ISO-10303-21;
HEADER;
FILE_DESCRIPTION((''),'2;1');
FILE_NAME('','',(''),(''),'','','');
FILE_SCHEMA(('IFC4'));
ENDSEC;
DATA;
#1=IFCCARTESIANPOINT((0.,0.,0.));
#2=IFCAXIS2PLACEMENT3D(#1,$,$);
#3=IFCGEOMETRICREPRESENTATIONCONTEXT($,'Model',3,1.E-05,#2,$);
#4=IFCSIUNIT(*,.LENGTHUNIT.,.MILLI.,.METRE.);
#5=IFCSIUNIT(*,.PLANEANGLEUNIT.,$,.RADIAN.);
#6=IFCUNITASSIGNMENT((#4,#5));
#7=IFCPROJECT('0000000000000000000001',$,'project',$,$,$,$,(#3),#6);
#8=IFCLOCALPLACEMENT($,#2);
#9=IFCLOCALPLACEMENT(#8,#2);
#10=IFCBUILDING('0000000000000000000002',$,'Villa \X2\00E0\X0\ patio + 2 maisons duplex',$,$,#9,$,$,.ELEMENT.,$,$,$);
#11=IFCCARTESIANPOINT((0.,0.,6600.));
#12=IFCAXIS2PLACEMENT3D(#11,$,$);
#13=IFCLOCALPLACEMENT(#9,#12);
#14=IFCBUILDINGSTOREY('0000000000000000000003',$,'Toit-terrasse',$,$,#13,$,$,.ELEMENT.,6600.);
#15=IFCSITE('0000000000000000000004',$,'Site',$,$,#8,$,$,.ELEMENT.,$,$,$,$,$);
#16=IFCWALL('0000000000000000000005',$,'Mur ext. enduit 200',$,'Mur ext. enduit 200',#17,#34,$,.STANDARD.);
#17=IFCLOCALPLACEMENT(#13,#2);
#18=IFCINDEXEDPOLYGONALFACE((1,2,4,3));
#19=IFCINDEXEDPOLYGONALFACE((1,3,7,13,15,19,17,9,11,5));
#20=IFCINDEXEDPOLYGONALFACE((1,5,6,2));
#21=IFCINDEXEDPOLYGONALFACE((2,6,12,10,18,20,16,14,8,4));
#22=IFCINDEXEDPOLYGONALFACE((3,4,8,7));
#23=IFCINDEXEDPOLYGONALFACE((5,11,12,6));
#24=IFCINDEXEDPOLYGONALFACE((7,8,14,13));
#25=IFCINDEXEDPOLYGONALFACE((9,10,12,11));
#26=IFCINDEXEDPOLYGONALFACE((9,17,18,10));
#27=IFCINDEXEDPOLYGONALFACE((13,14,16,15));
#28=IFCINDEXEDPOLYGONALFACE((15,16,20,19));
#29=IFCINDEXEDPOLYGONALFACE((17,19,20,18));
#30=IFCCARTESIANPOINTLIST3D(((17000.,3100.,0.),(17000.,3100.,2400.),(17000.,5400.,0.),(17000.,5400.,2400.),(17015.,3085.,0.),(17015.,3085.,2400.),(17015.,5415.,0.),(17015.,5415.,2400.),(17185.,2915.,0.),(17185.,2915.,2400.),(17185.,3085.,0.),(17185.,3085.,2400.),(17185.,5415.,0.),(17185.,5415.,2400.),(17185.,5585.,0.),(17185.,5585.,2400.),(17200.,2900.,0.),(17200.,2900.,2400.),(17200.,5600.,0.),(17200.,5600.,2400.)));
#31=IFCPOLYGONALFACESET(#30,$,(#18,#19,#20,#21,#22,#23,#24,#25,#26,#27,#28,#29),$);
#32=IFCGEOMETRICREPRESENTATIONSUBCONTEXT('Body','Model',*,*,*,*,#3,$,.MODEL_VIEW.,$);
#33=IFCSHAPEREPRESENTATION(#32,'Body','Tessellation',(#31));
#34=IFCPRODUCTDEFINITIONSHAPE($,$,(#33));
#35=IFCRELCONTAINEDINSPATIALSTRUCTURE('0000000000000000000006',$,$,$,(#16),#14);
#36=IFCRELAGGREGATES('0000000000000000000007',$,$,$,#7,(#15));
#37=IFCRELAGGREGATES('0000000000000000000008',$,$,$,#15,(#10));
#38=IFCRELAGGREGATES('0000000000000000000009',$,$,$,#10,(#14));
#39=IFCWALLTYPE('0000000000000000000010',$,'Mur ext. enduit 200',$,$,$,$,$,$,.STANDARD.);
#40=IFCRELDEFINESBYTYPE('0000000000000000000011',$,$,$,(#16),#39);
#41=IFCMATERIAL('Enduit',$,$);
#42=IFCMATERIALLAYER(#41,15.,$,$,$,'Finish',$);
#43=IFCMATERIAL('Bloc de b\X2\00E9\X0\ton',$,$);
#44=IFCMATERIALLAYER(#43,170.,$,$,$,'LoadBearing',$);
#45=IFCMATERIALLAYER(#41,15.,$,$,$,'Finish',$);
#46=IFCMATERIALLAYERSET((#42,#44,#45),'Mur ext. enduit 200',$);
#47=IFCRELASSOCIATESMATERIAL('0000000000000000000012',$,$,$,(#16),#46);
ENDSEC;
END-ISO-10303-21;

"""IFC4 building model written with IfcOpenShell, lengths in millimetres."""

from ifc_helpers import new_model, si_unit, frame, origin, place, context, subcontext, project, spatial, polyline, outline, extrude, material, layer, layer_set, layer_usage, type_object, element, save


model = new_model("IFC4")

# Units and contexts
model_context = context("Model", 3, precision=1e-05, world=origin())
body_context = subcontext(model_context, "Body", "Model", "MODEL_VIEW")
ifc_project = project(units=[si_unit("LENGTHUNIT", "METRE", prefix="MILLI"), si_unit("PLANEANGLEUNIT", "RADIAN")], contexts=[model_context])

# Site, building, storey
site_placement = place(None, origin())
site = spatial("IfcSite", under=ifc_project, at=site_placement, Name="Site", CompositionType="ELEMENT")
building_placement = place(site_placement, origin())
building = spatial("IfcBuilding", under=site, at=building_placement, Name="Villa à patio + 2 maisons duplex", CompositionType="ELEMENT")
storey_placement = place(building_placement, frame((0.0, 0.0, 6600.0)))
storey = spatial("IfcBuildingStorey", under=building, at=storey_placement, Name="Toit-terrasse", CompositionType="ELEMENT", Elevation=6600.0)

# Shared definitions
ifc_material_1 = material(Name="Enduit")
ifc_layer_1 = layer(ifc_material_1, 15.0, Category="Finish")
ifc_material_2 = material(Name="Bloc de béton")
ifc_layer_2 = layer(ifc_material_2, 170.0, Category="LoadBearing")
ifc_layer_3 = layer(ifc_material_1, 15.0, Category="Finish")
ifc_layer_set_1 = layer_set([ifc_layer_1, ifc_layer_2, ifc_layer_3], Name="Mur ext. enduit 200")
ifc_layer_usage_1 = layer_usage(ifc_layer_set_1, "AXIS2", "NEGATIVE", 100.0)
wall_type_1 = type_object("IfcWallType", Name="Mur ext. enduit 200", PredefinedType="STANDARD")

# Wall
wall_1_placement = place(storey_placement, frame((17100.0, 5500.0, 0.0), z_axis=(0.0, 0.0, 1.0), x_axis=(0.0, -1.0, 0.0)))
element("IfcWall", 1, at=wall_1_placement, inside=storey, type_object=wall_type_1, material=ifc_layer_usage_1, Name="Mur ext. enduit 200", ObjectType="Mur ext. enduit 200", PredefinedType="STANDARD", context=body_context, shape_type="SweptSolid", body=[
    extrude(outline(polyline([(100.0, -100.0), (85.0, -85.0), (85.0, 85.0), (-85.0, 85.0), (-100.0, 100.0), (2600.0, 100.0), (2585.0, 85.0), (2415.0, 85.0), (2415.0, -85.0), (2400.0, -100.0), (100.0, -100.0)])), origin(), (0.0, 0.0, 1.0), 2400.0),
])

save(model, "model.ifc")
